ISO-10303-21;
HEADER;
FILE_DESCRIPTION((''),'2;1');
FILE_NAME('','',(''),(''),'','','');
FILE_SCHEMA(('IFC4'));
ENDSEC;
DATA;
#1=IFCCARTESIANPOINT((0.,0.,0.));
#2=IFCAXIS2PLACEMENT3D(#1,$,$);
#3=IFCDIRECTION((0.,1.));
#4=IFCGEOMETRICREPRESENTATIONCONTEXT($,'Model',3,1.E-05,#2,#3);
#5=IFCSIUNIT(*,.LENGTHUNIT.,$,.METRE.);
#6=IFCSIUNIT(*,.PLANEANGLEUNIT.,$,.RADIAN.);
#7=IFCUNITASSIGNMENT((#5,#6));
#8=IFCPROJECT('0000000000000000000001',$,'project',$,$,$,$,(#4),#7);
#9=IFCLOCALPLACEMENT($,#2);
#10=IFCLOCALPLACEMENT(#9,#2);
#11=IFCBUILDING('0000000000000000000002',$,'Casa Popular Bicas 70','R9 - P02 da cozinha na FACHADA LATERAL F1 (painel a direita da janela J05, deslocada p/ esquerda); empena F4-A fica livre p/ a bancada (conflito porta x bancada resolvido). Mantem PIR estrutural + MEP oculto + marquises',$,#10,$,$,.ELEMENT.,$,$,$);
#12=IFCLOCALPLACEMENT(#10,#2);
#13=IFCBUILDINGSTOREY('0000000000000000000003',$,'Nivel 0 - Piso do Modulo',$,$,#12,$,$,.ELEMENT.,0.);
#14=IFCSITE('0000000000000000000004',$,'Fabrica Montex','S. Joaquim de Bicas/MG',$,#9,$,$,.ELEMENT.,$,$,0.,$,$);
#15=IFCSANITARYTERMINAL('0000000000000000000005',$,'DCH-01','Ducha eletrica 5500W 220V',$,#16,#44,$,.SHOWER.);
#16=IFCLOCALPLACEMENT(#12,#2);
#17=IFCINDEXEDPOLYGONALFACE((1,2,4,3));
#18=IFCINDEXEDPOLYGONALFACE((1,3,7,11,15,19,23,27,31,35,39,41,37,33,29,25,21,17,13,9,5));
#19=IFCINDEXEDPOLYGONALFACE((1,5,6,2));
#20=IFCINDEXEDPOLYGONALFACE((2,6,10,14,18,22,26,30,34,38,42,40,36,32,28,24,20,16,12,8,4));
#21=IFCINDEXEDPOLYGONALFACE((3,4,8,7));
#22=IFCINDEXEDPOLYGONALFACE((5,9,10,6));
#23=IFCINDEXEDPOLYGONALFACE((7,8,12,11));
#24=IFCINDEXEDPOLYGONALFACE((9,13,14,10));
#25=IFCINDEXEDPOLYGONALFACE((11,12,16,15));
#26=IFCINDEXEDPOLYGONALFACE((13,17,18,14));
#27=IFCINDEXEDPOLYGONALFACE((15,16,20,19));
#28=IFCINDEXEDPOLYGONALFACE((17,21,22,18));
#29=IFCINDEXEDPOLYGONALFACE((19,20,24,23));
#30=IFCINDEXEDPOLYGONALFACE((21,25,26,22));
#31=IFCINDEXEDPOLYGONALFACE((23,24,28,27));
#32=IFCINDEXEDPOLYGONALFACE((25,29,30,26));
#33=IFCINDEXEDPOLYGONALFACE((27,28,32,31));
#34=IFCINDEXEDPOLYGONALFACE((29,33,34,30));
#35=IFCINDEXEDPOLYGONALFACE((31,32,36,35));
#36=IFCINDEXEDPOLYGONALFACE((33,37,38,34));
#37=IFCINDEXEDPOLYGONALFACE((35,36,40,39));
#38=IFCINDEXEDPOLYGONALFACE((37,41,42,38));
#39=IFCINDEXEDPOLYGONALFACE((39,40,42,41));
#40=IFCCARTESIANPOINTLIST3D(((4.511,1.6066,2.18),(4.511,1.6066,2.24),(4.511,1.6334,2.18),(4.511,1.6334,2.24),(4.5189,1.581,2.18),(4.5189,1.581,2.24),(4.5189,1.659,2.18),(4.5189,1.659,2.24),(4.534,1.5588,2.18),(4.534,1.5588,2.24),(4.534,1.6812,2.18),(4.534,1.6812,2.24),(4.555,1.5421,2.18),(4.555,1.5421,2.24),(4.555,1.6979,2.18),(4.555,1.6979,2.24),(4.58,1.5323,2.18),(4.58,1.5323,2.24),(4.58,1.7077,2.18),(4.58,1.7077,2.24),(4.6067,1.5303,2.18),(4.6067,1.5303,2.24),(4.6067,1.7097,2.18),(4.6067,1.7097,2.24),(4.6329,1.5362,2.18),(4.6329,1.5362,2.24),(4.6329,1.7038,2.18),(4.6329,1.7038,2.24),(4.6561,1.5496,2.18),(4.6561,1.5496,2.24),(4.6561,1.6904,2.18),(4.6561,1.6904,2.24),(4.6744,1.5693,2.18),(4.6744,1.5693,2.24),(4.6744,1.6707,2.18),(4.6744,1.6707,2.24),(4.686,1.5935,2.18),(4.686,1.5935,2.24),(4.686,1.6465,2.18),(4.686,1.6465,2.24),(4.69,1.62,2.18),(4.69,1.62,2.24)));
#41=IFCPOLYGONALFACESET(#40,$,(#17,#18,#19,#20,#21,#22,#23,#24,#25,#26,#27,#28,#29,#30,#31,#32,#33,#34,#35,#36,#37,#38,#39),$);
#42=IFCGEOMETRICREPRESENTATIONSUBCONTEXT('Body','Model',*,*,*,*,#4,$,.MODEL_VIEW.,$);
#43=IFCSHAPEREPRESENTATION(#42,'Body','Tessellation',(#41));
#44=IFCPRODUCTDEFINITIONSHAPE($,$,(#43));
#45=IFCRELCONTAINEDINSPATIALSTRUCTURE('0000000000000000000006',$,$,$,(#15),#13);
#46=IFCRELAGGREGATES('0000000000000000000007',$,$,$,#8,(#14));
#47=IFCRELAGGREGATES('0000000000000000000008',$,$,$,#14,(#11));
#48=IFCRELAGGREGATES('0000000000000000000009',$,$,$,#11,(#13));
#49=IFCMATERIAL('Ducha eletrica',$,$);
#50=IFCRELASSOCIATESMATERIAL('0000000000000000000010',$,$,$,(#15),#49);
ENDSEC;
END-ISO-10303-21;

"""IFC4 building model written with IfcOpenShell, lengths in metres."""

from ifc_helpers import new_model, si_unit, direction, frame, origin, origin_2d, place, context, subcontext, project, spatial, circle, extrude, material, element, save


model = new_model("IFC4")

# Units and contexts
model_context = context("Model", 3, precision=1e-05, world=origin(), true_north=direction((0.0, 1.0)))
body_context = subcontext(model_context, "Body", "Model", "MODEL_VIEW")
ifc_project = project(units=[si_unit("LENGTHUNIT", "METRE"), si_unit("PLANEANGLEUNIT", "RADIAN")], contexts=[model_context])

# Site, building, storey
site_placement = place(None, origin())
site = spatial("IfcSite", under=ifc_project, at=site_placement, Name="Fabrica Montex", Description="S. Joaquim de Bicas/MG", CompositionType="ELEMENT", RefElevation=0.0)
building_placement = place(site_placement, origin())
building = spatial("IfcBuilding", under=site, at=building_placement, Name="Casa Popular Bicas 70", Description="R9 - P02 da cozinha na FACHADA LATERAL F1 (painel a direita da janela J05, deslocada p/ esquerda); empena F4-A fica livre p/ a bancada (conflito porta x bancada resolvido). Mantem PIR estrutural + MEP oculto + marquises", CompositionType="ELEMENT")
storey_placement = place(building_placement, origin())
storey = spatial("IfcBuildingStorey", under=building, at=storey_placement, Name="Nivel 0 - Piso do Modulo", CompositionType="ELEMENT", Elevation=0.0)

# Sanitary terminal
ifc_material_1 = material(Name="Ducha eletrica")
sanitary_terminal_1_placement = place(storey_placement, frame((4.6, 1.62, 2.18)))
element("IfcSanitaryTerminal", 1, at=sanitary_terminal_1_placement, inside=storey, material=ifc_material_1, Name="DCH-01", Description="Ducha eletrica 5500W 220V", PredefinedType="SHOWER", context=body_context, shape_type="SweptSolid", body=[
    extrude(circle(Radius=0.09, at=origin_2d()), origin(), (0.0, 0.0, 1.0), 0.06),
])

save(model, "model.ifc")
